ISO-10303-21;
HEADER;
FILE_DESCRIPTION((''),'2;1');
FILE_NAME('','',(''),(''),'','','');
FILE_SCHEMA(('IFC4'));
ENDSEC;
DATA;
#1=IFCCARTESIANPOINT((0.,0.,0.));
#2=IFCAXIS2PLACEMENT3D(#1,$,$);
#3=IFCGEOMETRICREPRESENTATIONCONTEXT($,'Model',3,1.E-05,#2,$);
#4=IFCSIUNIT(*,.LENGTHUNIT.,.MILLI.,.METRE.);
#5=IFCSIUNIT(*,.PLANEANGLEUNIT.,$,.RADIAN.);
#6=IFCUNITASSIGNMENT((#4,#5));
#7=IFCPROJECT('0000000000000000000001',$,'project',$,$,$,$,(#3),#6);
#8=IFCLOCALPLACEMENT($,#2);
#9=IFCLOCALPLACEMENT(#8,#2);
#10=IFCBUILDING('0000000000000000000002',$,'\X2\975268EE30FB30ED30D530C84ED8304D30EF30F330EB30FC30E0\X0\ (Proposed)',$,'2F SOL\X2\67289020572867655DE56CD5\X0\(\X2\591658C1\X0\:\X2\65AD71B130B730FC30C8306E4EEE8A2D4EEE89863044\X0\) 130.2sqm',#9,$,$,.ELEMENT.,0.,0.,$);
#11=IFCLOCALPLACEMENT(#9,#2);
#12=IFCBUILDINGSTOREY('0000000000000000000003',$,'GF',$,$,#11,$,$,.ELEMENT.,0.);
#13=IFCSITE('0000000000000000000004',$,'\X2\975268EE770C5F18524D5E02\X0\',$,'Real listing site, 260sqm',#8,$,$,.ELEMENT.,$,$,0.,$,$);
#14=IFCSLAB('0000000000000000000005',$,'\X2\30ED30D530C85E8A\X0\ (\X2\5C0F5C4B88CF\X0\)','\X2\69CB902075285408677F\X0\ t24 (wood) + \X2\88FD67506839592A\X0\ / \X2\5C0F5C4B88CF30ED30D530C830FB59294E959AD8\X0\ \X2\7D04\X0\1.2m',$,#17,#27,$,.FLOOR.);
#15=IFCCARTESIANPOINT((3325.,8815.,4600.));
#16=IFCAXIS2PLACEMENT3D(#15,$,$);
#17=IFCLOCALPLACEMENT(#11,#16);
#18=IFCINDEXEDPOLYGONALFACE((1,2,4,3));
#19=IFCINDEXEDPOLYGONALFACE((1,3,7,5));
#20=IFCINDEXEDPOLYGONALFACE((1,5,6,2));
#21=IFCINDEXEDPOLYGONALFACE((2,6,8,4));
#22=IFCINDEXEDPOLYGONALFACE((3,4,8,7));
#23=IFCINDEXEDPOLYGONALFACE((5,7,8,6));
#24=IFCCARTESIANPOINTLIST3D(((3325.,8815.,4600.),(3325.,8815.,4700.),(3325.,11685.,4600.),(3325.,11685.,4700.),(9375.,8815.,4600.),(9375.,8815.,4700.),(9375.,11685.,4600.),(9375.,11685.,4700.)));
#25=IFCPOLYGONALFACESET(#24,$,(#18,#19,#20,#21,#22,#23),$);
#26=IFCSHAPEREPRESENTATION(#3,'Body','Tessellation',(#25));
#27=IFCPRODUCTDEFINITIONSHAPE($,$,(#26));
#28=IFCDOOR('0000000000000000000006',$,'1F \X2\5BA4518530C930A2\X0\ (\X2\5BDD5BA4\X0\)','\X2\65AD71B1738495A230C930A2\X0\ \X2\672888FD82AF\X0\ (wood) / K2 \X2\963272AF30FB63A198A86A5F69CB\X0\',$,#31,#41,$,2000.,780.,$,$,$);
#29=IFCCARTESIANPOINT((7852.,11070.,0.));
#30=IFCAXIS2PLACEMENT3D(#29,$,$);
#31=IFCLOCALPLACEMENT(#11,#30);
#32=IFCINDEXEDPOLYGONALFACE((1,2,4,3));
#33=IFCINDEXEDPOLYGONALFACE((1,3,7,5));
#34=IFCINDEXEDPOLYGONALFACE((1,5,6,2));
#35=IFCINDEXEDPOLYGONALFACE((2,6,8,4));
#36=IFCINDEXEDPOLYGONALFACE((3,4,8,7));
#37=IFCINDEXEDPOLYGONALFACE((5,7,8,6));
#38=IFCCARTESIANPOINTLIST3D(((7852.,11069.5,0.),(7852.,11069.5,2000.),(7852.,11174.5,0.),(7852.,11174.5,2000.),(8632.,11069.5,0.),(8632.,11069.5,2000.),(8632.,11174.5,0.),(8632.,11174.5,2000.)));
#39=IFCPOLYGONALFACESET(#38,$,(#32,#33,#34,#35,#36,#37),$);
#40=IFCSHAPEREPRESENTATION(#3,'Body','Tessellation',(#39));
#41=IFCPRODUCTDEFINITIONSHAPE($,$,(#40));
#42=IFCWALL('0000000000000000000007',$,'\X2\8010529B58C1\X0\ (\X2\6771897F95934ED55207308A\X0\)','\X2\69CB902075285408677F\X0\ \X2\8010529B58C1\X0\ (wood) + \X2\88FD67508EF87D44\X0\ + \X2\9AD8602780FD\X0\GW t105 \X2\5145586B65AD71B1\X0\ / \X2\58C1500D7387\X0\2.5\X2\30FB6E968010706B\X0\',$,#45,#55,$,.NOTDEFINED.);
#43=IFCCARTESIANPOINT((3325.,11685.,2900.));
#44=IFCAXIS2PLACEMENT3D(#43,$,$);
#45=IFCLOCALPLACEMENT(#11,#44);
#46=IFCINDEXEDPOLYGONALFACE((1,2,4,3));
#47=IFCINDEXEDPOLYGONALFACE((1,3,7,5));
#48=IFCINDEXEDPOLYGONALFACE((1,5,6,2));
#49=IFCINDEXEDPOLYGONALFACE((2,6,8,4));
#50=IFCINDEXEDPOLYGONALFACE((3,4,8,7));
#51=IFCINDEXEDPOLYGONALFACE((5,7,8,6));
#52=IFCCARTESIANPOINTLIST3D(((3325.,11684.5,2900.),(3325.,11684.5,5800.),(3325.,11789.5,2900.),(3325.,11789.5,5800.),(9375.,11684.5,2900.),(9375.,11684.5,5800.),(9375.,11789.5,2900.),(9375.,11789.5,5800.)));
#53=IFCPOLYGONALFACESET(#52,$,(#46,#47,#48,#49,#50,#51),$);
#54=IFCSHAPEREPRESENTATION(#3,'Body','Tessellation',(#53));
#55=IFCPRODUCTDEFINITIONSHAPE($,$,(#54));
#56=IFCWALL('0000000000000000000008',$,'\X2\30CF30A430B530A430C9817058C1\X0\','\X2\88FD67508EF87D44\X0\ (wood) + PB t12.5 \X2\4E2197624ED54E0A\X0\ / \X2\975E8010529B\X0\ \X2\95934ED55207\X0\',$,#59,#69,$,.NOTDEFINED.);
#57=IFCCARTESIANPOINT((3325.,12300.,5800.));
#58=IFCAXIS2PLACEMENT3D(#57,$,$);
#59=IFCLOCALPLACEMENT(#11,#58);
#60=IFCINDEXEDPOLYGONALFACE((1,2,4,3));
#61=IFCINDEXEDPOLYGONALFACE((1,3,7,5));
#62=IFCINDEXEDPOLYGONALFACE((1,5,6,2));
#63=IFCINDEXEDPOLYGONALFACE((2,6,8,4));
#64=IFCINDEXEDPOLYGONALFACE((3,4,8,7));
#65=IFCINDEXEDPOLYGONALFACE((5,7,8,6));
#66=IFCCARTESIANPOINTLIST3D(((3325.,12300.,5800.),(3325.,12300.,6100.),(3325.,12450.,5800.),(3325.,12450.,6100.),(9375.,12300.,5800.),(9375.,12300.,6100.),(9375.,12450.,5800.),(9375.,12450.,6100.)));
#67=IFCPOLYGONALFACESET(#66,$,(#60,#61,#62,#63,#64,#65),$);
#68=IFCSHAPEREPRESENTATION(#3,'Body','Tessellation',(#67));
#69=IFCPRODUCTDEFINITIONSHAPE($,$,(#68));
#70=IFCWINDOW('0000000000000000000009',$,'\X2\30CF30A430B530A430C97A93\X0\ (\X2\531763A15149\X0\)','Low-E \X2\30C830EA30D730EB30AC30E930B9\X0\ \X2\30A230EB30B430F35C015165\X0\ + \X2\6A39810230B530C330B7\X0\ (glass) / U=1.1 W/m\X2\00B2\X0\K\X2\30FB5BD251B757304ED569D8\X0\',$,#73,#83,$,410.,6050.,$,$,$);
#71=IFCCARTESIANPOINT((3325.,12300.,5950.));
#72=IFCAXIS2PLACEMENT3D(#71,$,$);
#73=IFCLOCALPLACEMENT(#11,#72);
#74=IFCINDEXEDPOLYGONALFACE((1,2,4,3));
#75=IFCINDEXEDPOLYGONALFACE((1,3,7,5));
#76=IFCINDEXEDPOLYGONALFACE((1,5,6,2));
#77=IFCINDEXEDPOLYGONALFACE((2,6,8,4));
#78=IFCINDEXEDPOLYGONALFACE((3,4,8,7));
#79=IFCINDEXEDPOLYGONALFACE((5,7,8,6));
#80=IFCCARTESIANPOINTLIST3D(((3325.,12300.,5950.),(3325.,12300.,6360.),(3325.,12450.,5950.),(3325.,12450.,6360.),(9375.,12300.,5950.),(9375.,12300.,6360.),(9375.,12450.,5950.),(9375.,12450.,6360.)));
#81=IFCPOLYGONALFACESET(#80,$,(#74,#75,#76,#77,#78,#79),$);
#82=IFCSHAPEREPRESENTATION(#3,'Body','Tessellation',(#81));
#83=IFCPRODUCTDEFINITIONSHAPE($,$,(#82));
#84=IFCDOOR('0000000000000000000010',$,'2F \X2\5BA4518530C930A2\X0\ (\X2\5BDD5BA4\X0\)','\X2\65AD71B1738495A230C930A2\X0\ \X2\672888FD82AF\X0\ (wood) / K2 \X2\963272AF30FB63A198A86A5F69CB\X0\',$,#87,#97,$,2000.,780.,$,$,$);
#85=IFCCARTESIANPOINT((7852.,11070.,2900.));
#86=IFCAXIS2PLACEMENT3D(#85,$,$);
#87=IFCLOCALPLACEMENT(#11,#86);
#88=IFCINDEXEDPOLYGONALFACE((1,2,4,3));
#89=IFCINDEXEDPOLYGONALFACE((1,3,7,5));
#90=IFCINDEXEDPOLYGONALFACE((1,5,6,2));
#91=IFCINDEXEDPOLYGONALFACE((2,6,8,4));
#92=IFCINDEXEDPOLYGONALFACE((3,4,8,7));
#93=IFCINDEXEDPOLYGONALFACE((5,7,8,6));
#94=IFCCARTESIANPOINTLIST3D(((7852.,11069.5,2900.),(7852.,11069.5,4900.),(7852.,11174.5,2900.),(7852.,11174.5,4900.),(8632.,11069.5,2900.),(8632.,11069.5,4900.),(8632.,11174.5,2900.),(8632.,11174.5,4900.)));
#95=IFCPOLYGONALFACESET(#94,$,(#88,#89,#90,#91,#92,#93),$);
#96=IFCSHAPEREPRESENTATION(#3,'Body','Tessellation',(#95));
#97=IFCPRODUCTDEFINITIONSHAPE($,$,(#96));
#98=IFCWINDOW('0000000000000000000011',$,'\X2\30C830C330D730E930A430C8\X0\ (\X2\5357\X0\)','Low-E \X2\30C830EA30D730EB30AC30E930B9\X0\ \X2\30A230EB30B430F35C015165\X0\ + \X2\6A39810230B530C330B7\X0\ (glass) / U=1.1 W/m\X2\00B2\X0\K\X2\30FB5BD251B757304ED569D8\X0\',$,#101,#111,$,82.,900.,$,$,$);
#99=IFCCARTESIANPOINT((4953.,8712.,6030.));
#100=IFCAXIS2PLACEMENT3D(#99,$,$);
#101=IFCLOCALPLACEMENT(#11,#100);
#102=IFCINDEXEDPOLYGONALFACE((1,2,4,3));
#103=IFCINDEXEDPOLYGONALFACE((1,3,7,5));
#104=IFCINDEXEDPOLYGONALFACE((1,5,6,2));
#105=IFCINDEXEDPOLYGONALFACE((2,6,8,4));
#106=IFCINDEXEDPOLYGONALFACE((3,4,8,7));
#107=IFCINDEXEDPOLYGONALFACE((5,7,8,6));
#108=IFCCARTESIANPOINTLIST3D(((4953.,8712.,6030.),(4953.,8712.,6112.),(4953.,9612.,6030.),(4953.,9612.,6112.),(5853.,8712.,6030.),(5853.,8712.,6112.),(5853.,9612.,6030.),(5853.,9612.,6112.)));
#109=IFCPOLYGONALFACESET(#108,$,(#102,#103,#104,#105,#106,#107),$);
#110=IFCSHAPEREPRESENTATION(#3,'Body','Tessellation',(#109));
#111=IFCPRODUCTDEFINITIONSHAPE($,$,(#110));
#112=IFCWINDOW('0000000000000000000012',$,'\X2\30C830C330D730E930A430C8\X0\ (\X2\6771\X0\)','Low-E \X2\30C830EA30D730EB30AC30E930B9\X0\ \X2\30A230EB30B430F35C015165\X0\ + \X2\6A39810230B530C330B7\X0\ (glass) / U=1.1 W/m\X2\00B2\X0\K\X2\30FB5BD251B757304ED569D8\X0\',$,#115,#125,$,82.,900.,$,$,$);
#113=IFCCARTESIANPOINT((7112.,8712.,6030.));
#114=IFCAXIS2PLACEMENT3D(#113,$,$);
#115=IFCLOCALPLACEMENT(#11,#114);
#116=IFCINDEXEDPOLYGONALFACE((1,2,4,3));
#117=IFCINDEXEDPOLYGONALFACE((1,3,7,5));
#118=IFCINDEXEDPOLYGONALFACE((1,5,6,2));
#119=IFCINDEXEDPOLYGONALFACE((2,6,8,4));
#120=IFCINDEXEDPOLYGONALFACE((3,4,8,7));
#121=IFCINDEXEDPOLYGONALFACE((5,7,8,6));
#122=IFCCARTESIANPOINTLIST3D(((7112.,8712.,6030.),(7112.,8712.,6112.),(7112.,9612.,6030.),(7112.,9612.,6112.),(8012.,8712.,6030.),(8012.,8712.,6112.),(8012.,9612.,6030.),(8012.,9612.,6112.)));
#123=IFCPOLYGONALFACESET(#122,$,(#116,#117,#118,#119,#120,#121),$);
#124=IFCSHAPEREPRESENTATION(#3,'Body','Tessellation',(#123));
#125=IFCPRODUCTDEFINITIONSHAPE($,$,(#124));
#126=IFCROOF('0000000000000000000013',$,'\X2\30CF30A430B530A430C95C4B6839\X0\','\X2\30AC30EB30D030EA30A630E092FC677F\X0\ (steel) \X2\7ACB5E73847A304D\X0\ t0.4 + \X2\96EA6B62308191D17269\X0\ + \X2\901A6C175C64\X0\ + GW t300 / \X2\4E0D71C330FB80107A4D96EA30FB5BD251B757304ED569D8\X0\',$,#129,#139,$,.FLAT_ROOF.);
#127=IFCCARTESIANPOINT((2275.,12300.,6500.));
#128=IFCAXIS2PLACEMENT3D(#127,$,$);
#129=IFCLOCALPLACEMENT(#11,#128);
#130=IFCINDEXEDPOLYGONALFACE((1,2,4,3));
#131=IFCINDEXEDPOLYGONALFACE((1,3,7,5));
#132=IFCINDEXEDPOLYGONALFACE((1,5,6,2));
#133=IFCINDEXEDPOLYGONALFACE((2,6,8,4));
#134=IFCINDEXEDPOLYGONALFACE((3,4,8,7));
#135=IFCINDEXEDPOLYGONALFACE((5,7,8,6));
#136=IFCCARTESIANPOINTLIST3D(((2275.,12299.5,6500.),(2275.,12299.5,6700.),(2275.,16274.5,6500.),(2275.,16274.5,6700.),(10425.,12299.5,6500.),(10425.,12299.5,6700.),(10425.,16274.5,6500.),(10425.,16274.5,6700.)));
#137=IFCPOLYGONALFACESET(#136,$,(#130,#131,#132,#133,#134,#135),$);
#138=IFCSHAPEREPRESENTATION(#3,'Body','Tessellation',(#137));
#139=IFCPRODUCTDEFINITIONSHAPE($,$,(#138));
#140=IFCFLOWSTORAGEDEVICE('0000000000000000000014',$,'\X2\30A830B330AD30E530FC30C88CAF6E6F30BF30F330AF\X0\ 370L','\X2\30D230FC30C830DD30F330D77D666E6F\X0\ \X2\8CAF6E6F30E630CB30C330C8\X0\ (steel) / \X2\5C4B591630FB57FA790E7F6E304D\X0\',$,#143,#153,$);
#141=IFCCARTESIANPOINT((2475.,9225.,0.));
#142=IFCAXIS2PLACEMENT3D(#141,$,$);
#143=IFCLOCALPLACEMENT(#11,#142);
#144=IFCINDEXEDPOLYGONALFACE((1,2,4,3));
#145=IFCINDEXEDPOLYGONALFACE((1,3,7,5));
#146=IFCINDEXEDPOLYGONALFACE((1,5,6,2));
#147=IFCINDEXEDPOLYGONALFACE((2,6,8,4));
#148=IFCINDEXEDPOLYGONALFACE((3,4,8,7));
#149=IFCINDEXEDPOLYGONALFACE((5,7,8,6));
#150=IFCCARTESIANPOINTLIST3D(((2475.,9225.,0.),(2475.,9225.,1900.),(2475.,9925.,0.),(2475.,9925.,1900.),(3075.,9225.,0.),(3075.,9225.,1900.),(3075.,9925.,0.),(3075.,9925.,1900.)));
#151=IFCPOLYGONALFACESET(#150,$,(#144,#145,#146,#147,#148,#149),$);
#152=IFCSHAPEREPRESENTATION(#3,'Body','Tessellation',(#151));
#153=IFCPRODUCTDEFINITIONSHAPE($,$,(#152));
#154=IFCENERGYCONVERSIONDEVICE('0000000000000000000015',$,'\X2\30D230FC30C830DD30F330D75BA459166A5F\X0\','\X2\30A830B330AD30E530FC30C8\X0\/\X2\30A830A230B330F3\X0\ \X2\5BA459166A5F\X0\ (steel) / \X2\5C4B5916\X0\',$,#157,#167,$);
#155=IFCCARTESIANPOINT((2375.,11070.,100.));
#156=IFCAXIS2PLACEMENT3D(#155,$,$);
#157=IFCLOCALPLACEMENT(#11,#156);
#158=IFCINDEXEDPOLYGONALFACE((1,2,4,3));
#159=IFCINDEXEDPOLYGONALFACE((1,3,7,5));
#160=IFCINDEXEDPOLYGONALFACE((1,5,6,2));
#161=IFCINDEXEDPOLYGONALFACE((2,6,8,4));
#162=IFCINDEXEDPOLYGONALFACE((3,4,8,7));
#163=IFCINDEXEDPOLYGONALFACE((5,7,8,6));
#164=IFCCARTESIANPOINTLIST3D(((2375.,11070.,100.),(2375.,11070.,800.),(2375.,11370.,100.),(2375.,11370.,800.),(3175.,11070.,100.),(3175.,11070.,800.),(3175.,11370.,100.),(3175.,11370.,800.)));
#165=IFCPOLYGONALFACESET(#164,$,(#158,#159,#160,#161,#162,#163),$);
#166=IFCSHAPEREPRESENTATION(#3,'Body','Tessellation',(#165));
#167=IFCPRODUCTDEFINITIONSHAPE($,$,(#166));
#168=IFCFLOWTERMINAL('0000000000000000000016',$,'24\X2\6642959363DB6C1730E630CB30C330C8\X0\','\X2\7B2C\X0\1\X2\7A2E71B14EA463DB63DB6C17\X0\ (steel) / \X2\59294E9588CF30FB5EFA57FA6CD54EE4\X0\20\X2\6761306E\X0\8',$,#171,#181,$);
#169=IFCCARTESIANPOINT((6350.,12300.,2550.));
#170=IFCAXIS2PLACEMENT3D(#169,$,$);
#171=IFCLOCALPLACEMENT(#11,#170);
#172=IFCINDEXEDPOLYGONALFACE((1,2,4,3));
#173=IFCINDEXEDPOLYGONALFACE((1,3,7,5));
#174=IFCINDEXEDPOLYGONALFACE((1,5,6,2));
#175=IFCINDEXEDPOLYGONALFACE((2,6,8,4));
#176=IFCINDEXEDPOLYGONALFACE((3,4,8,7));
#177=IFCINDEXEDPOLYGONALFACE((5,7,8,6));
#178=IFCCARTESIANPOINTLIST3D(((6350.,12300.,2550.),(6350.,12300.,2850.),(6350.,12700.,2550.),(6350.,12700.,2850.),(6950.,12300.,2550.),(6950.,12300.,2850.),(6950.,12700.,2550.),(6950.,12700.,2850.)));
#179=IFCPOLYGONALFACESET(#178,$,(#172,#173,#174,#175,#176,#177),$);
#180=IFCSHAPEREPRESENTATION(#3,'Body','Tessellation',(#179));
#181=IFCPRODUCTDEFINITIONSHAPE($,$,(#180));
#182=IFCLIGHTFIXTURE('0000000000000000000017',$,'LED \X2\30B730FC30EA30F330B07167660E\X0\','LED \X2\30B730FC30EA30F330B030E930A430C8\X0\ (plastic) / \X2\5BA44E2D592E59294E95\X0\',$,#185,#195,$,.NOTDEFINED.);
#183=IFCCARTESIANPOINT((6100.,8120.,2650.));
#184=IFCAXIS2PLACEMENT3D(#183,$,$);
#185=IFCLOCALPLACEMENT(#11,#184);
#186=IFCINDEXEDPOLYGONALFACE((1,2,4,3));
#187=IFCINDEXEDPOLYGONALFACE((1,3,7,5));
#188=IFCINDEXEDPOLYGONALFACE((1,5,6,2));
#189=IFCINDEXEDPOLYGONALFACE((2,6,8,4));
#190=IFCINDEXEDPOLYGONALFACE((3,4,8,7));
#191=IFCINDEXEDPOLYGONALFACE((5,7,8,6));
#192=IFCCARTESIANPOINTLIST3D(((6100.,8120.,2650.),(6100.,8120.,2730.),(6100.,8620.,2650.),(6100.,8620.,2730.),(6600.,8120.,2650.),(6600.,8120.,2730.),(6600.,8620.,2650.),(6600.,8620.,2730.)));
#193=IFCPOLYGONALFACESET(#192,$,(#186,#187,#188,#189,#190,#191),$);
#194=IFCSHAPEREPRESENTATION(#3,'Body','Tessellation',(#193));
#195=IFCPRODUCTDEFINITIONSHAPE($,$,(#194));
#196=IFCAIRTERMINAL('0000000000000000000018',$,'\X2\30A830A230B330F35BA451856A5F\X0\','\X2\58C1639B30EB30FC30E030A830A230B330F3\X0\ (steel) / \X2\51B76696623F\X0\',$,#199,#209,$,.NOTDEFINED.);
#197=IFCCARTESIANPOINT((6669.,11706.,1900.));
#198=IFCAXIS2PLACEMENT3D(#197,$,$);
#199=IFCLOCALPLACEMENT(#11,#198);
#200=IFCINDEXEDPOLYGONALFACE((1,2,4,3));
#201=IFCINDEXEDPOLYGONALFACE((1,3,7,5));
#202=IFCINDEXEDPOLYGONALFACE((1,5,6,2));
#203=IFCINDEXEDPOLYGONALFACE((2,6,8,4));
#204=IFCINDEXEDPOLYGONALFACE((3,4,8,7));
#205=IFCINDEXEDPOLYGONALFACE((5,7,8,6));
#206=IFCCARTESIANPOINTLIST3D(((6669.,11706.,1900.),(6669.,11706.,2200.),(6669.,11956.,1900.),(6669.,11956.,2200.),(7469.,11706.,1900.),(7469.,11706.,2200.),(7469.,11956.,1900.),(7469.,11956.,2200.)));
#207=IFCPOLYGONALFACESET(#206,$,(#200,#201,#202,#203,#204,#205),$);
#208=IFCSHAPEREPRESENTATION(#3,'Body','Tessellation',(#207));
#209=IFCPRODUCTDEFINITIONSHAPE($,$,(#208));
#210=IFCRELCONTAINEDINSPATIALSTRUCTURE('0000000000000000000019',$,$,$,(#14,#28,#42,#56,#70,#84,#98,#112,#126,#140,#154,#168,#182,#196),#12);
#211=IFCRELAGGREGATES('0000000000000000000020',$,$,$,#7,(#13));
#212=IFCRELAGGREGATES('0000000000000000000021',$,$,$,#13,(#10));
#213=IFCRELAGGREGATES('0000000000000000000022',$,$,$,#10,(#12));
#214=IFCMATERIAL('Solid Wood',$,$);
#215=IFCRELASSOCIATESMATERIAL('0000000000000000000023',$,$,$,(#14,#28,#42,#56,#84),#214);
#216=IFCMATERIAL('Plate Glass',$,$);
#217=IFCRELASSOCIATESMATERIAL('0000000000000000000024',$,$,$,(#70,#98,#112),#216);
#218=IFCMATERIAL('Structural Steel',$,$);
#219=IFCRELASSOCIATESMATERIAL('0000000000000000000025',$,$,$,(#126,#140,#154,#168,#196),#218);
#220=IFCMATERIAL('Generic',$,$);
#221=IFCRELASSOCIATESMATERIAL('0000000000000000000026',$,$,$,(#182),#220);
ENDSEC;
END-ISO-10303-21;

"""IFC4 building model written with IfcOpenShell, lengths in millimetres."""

from ifc_helpers import new_model, si_unit, frame, frame_2d, origin, place, context, project, spatial, rectangle, extrude, material, element, fill, save


model = new_model("IFC4")

# Units and contexts
model_context = context("Model", 3, precision=1e-05, world=origin())
ifc_project = project(units=[si_unit("LENGTHUNIT", "METRE", prefix="MILLI"), si_unit("PLANEANGLEUNIT", "RADIAN")], contexts=[model_context])

# Site, building, storey
site_placement = place(None, origin())
site = spatial("IfcSite", under=ifc_project, at=site_placement, Name="青森県弘前市", ObjectType="Real listing site, 260sqm", CompositionType="ELEMENT", RefElevation=0.0)
building_placement = place(site_placement, origin())
building = spatial("IfcBuilding", under=site, at=building_placement, Name="青森・ロフト付きワンルーム (Proposed)", ObjectType="2F SOL木造在来工法(外壁:断熱シートの仮設仮覆い) 130.2sqm", CompositionType="ELEMENT", ElevationOfRefHeight=0.0, ElevationOfTerrain=0.0)
storey_placement = place(building_placement, origin())
storey = spatial("IfcBuildingStorey", under=building, at=storey_placement, Name="GF", CompositionType="ELEMENT", Elevation=0.0)

# Shared definitions
ifc_material_1 = material(Name="Solid Wood")

# Slab
slab_placement = place(storey_placement, frame((3325.0, 8815.0, 4600.0)))
element("IfcSlab", 1, at=slab_placement, inside=storey, material=ifc_material_1, Name="ロフト床 (小屋裏)", Description="構造用合板 t24 (wood) + 製材根太 / 小屋裏ロフト・天井高 約1.2m", PredefinedType="FLOOR", context=model_context, shape_type="SweptSolid", body=[
    extrude(rectangle(XDim=6050.0, YDim=2870.0, at=frame_2d((3025.0, 1435.0))), frame((3325.0, 8815.0, 4600.0)), (0.0, 0.0, 1.0), 100.0),
])

# Door
door_1_placement = place(storey_placement, frame((7852.0, 11070.0, 0.0)))
element("IfcDoor", 2, at=door_1_placement, inside=storey, material=ifc_material_1, Name="1F 室内ドア (寝室)", Description="断熱玄関ドア 木製芯 (wood) / K2 防犯・採風機構", OverallHeight=2000.0, OverallWidth=780.0, context=model_context, shape_type="SweptSolid", body=[
    extrude(rectangle(XDim=780.0, YDim=105.0, at=frame_2d((390.0, 52.0))), frame((7852.0, 11070.0, 0.0)), (0.0, 0.0, 1.0), 2000.0),
])

# Wall
wall_1_placement = place(storey_placement, frame((3325.0, 11685.0, 2900.0)))
element("IfcWall", 3, at=wall_1_placement, inside=storey, material=ifc_material_1, Name="耐力壁 (東西間仕切り)", Description="構造用合板 耐力壁 (wood) + 製材軸組 + 高性能GW t105 充填断熱 / 壁倍率2.5・準耐火", PredefinedType="NOTDEFINED", context=model_context, shape_type="SweptSolid", body=[
    extrude(rectangle(XDim=6050.0, YDim=105.0, at=frame_2d((3025.0, 52.0))), frame((3325.0, 11685.0, 2900.0)), (0.0, 0.0, 1.0), 2900.0),
])

# Wall, opening, window
wall_2_placement = place(storey_placement, frame((3325.0, 12300.0, 5800.0)))
wall_2 = element("IfcWall", 4, at=wall_2_placement, inside=storey, material=ifc_material_1, Name="ハイサイド腰壁", Description="製材軸組 (wood) + PB t12.5 両面仕上 / 非耐力 間仕切", PredefinedType="NOTDEFINED", context=model_context, shape_type="SweptSolid", body=[
    extrude(rectangle(XDim=6050.0, YDim=150.0, at=frame_2d((3025.0, 75.0))), frame((3325.0, 12300.0, 5800.0)), (0.0, 0.0, 1.0), 700.0),
])
opening_1_placement = place(storey_placement, frame((3325.0, 12300.0, 5950.0)))
opening_1 = element("IfcOpeningElement", 5, at=opening_1_placement, cuts=wall_2, PredefinedType="NOTDEFINED", context=model_context, shape_type="SweptSolid", body=[
    extrude(rectangle(XDim=6050.0, YDim=150.0, at=frame_2d((3025.0, 75.0))), frame((3325.0, 12300.0, 5950.0)), (0.0, 0.0, 1.0), 410.0),
])
ifc_material_2 = material(Name="Plate Glass")
window_1_placement = place(storey_placement, frame((3325.0, 12300.0, 5950.0)))
window_1 = element("IfcWindow", 6, at=window_1_placement, inside=storey, material=ifc_material_2, Name="ハイサイド窓 (北採光)", Description="Low-E トリプルガラス アルゴン封入 + 樹脂サッシ (glass) / U=1.1 W/m²K・寒冷地仕様", OverallHeight=410.0, OverallWidth=6050.0, context=model_context, shape_type="SweptSolid", body=[
    extrude(rectangle(XDim=6050.0, YDim=150.0, at=frame_2d((3025.0, 75.0))), frame((3325.0, 12300.0, 5950.0)), (0.0, 0.0, 1.0), 410.0),
])
fill(opening_1, window_1)

# Door
door_2_placement = place(storey_placement, frame((7852.0, 11070.0, 2900.0)))
element("IfcDoor", 7, at=door_2_placement, inside=storey, material=ifc_material_1, Name="2F 室内ドア (寝室)", Description="断熱玄関ドア 木製芯 (wood) / K2 防犯・採風機構", OverallHeight=2000.0, OverallWidth=780.0, context=model_context, shape_type="SweptSolid", body=[
    extrude(rectangle(XDim=780.0, YDim=105.0, at=frame_2d((390.0, 52.0))), frame((7852.0, 11070.0, 2900.0)), (0.0, 0.0, 1.0), 2000.0),
])

# Windows
window_2_placement = place(storey_placement, frame((4953.0, 8712.0, 6030.0)))
element("IfcWindow", 8, at=window_2_placement, inside=storey, material=ifc_material_2, Name="トップライト (南)", Description="Low-E トリプルガラス アルゴン封入 + 樹脂サッシ (glass) / U=1.1 W/m²K・寒冷地仕様", OverallHeight=82.0, OverallWidth=900.0, context=model_context, shape_type="SweptSolid", body=[
    extrude(rectangle(XDim=900.0, YDim=900.0, at=frame_2d((450.0, 450.0))), frame((4953.0, 8712.0, 6030.0)), (0.0, 0.0, 1.0), 82.0),
])
window_3_placement = place(storey_placement, frame((7112.0, 8712.0, 6030.0)))
element("IfcWindow", 9, at=window_3_placement, inside=storey, material=ifc_material_2, Name="トップライト (東)", Description="Low-E トリプルガラス アルゴン封入 + 樹脂サッシ (glass) / U=1.1 W/m²K・寒冷地仕様", OverallHeight=82.0, OverallWidth=900.0, context=model_context, shape_type="SweptSolid", body=[
    extrude(rectangle(XDim=900.0, YDim=900.0, at=frame_2d((450.0, 450.0))), frame((7112.0, 8712.0, 6030.0)), (0.0, 0.0, 1.0), 82.0),
])

# Roof
ifc_material_3 = material(Name="Structural Steel")
roof_placement = place(storey_placement, frame((2275.0, 12300.0, 6500.0)))
element("IfcRoof", 10, at=roof_placement, inside=storey, material=ifc_material_3, Name="ハイサイド屋根", Description="ガルバリウム鋼板 (steel) 立平葺き t0.4 + 雪止め金物 + 通気層 + GW t300 / 不燃・耐積雪・寒冷地仕様", PredefinedType="FLAT_ROOF", context=model_context, shape_type="SweptSolid", body=[
    extrude(rectangle(XDim=8150.0, YDim=3975.0, at=frame_2d((4075.0, 1987.0))), frame((2275.0, 12300.0, 6500.0)), (0.0, 0.0, 1.0), 200.0),
])

# Flow storage device
flow_storage_device_placement = place(storey_placement, frame((2475.0, 9225.0, 0.0)))
element("IfcFlowStorageDevice", 11, at=flow_storage_device_placement, inside=storey, material=ifc_material_3, Name="エコキュート貯湯タンク 370L", Description="ヒートポンプ給湯 貯湯ユニット (steel) / 屋外・基礎置き", context=model_context, shape_type="SweptSolid", body=[
    extrude(rectangle(XDim=600.0, YDim=700.0, at=frame_2d((300.0, 350.0))), frame((2475.0, 9225.0, 0.0)), (0.0, 0.0, 1.0), 1900.0),
])

# Energy conversion device
energy_conversion_device_placement = place(storey_placement, frame((2375.0, 11070.0, 100.0)))
element("IfcEnergyConversionDevice", 12, at=energy_conversion_device_placement, inside=storey, material=ifc_material_3, Name="ヒートポンプ室外機", Description="エコキュート/エアコン 室外機 (steel) / 屋外", context=model_context, shape_type="SweptSolid", body=[
    extrude(rectangle(XDim=800.0, YDim=300.0, at=frame_2d((400.0, 150.0))), frame((2375.0, 11070.0, 100.0)), (0.0, 0.0, 1.0), 700.0),
])

# Flow terminal
flow_terminal_placement = place(storey_placement, frame((6350.0, 12300.0, 2550.0)))
element("IfcFlowTerminal", 13, at=flow_terminal_placement, inside=storey, material=ifc_material_3, Name="24時間換気ユニット", Description="第1種熱交換換気 (steel) / 天井裏・建基法令20条の8", context=model_context, shape_type="SweptSolid", body=[
    extrude(rectangle(XDim=600.0, YDim=400.0, at=frame_2d((300.0, 200.0))), frame((6350.0, 12300.0, 2550.0)), (0.0, 0.0, 1.0), 300.0),
])

# Light fixture
ifc_material_4 = material(Name="Generic")
light_fixture_1_placement = place(storey_placement, frame((6100.0, 8120.0, 2650.0)))
element("IfcLightFixture", 14, at=light_fixture_1_placement, inside=storey, material=ifc_material_4, Name="LED シーリング照明", Description="LED シーリングライト (plastic) / 室中央天井", PredefinedType="NOTDEFINED", context=model_context, shape_type="SweptSolid", body=[
    extrude(rectangle(XDim=500.0, YDim=500.0, at=frame_2d((250.0, 250.0))), frame((6100.0, 8120.0, 2650.0)), (0.0, 0.0, 1.0), 80.0),
])

# Air terminal
air_terminal_placement = place(storey_placement, frame((6669.0, 11706.0, 1900.0)))
element("IfcAirTerminal", 15, at=air_terminal_placement, inside=storey, material=ifc_material_3, Name="エアコン室内機", Description="壁掛ルームエアコン (steel) / 冷暖房", PredefinedType="NOTDEFINED", context=model_context, shape_type="SweptSolid", body=[
    extrude(rectangle(XDim=800.0, YDim=250.0, at=frame_2d((400.0, 125.0))), frame((6669.0, 11706.0, 1900.0)), (0.0, 0.0, 1.0), 300.0),
])

save(model, "model.ifc")
